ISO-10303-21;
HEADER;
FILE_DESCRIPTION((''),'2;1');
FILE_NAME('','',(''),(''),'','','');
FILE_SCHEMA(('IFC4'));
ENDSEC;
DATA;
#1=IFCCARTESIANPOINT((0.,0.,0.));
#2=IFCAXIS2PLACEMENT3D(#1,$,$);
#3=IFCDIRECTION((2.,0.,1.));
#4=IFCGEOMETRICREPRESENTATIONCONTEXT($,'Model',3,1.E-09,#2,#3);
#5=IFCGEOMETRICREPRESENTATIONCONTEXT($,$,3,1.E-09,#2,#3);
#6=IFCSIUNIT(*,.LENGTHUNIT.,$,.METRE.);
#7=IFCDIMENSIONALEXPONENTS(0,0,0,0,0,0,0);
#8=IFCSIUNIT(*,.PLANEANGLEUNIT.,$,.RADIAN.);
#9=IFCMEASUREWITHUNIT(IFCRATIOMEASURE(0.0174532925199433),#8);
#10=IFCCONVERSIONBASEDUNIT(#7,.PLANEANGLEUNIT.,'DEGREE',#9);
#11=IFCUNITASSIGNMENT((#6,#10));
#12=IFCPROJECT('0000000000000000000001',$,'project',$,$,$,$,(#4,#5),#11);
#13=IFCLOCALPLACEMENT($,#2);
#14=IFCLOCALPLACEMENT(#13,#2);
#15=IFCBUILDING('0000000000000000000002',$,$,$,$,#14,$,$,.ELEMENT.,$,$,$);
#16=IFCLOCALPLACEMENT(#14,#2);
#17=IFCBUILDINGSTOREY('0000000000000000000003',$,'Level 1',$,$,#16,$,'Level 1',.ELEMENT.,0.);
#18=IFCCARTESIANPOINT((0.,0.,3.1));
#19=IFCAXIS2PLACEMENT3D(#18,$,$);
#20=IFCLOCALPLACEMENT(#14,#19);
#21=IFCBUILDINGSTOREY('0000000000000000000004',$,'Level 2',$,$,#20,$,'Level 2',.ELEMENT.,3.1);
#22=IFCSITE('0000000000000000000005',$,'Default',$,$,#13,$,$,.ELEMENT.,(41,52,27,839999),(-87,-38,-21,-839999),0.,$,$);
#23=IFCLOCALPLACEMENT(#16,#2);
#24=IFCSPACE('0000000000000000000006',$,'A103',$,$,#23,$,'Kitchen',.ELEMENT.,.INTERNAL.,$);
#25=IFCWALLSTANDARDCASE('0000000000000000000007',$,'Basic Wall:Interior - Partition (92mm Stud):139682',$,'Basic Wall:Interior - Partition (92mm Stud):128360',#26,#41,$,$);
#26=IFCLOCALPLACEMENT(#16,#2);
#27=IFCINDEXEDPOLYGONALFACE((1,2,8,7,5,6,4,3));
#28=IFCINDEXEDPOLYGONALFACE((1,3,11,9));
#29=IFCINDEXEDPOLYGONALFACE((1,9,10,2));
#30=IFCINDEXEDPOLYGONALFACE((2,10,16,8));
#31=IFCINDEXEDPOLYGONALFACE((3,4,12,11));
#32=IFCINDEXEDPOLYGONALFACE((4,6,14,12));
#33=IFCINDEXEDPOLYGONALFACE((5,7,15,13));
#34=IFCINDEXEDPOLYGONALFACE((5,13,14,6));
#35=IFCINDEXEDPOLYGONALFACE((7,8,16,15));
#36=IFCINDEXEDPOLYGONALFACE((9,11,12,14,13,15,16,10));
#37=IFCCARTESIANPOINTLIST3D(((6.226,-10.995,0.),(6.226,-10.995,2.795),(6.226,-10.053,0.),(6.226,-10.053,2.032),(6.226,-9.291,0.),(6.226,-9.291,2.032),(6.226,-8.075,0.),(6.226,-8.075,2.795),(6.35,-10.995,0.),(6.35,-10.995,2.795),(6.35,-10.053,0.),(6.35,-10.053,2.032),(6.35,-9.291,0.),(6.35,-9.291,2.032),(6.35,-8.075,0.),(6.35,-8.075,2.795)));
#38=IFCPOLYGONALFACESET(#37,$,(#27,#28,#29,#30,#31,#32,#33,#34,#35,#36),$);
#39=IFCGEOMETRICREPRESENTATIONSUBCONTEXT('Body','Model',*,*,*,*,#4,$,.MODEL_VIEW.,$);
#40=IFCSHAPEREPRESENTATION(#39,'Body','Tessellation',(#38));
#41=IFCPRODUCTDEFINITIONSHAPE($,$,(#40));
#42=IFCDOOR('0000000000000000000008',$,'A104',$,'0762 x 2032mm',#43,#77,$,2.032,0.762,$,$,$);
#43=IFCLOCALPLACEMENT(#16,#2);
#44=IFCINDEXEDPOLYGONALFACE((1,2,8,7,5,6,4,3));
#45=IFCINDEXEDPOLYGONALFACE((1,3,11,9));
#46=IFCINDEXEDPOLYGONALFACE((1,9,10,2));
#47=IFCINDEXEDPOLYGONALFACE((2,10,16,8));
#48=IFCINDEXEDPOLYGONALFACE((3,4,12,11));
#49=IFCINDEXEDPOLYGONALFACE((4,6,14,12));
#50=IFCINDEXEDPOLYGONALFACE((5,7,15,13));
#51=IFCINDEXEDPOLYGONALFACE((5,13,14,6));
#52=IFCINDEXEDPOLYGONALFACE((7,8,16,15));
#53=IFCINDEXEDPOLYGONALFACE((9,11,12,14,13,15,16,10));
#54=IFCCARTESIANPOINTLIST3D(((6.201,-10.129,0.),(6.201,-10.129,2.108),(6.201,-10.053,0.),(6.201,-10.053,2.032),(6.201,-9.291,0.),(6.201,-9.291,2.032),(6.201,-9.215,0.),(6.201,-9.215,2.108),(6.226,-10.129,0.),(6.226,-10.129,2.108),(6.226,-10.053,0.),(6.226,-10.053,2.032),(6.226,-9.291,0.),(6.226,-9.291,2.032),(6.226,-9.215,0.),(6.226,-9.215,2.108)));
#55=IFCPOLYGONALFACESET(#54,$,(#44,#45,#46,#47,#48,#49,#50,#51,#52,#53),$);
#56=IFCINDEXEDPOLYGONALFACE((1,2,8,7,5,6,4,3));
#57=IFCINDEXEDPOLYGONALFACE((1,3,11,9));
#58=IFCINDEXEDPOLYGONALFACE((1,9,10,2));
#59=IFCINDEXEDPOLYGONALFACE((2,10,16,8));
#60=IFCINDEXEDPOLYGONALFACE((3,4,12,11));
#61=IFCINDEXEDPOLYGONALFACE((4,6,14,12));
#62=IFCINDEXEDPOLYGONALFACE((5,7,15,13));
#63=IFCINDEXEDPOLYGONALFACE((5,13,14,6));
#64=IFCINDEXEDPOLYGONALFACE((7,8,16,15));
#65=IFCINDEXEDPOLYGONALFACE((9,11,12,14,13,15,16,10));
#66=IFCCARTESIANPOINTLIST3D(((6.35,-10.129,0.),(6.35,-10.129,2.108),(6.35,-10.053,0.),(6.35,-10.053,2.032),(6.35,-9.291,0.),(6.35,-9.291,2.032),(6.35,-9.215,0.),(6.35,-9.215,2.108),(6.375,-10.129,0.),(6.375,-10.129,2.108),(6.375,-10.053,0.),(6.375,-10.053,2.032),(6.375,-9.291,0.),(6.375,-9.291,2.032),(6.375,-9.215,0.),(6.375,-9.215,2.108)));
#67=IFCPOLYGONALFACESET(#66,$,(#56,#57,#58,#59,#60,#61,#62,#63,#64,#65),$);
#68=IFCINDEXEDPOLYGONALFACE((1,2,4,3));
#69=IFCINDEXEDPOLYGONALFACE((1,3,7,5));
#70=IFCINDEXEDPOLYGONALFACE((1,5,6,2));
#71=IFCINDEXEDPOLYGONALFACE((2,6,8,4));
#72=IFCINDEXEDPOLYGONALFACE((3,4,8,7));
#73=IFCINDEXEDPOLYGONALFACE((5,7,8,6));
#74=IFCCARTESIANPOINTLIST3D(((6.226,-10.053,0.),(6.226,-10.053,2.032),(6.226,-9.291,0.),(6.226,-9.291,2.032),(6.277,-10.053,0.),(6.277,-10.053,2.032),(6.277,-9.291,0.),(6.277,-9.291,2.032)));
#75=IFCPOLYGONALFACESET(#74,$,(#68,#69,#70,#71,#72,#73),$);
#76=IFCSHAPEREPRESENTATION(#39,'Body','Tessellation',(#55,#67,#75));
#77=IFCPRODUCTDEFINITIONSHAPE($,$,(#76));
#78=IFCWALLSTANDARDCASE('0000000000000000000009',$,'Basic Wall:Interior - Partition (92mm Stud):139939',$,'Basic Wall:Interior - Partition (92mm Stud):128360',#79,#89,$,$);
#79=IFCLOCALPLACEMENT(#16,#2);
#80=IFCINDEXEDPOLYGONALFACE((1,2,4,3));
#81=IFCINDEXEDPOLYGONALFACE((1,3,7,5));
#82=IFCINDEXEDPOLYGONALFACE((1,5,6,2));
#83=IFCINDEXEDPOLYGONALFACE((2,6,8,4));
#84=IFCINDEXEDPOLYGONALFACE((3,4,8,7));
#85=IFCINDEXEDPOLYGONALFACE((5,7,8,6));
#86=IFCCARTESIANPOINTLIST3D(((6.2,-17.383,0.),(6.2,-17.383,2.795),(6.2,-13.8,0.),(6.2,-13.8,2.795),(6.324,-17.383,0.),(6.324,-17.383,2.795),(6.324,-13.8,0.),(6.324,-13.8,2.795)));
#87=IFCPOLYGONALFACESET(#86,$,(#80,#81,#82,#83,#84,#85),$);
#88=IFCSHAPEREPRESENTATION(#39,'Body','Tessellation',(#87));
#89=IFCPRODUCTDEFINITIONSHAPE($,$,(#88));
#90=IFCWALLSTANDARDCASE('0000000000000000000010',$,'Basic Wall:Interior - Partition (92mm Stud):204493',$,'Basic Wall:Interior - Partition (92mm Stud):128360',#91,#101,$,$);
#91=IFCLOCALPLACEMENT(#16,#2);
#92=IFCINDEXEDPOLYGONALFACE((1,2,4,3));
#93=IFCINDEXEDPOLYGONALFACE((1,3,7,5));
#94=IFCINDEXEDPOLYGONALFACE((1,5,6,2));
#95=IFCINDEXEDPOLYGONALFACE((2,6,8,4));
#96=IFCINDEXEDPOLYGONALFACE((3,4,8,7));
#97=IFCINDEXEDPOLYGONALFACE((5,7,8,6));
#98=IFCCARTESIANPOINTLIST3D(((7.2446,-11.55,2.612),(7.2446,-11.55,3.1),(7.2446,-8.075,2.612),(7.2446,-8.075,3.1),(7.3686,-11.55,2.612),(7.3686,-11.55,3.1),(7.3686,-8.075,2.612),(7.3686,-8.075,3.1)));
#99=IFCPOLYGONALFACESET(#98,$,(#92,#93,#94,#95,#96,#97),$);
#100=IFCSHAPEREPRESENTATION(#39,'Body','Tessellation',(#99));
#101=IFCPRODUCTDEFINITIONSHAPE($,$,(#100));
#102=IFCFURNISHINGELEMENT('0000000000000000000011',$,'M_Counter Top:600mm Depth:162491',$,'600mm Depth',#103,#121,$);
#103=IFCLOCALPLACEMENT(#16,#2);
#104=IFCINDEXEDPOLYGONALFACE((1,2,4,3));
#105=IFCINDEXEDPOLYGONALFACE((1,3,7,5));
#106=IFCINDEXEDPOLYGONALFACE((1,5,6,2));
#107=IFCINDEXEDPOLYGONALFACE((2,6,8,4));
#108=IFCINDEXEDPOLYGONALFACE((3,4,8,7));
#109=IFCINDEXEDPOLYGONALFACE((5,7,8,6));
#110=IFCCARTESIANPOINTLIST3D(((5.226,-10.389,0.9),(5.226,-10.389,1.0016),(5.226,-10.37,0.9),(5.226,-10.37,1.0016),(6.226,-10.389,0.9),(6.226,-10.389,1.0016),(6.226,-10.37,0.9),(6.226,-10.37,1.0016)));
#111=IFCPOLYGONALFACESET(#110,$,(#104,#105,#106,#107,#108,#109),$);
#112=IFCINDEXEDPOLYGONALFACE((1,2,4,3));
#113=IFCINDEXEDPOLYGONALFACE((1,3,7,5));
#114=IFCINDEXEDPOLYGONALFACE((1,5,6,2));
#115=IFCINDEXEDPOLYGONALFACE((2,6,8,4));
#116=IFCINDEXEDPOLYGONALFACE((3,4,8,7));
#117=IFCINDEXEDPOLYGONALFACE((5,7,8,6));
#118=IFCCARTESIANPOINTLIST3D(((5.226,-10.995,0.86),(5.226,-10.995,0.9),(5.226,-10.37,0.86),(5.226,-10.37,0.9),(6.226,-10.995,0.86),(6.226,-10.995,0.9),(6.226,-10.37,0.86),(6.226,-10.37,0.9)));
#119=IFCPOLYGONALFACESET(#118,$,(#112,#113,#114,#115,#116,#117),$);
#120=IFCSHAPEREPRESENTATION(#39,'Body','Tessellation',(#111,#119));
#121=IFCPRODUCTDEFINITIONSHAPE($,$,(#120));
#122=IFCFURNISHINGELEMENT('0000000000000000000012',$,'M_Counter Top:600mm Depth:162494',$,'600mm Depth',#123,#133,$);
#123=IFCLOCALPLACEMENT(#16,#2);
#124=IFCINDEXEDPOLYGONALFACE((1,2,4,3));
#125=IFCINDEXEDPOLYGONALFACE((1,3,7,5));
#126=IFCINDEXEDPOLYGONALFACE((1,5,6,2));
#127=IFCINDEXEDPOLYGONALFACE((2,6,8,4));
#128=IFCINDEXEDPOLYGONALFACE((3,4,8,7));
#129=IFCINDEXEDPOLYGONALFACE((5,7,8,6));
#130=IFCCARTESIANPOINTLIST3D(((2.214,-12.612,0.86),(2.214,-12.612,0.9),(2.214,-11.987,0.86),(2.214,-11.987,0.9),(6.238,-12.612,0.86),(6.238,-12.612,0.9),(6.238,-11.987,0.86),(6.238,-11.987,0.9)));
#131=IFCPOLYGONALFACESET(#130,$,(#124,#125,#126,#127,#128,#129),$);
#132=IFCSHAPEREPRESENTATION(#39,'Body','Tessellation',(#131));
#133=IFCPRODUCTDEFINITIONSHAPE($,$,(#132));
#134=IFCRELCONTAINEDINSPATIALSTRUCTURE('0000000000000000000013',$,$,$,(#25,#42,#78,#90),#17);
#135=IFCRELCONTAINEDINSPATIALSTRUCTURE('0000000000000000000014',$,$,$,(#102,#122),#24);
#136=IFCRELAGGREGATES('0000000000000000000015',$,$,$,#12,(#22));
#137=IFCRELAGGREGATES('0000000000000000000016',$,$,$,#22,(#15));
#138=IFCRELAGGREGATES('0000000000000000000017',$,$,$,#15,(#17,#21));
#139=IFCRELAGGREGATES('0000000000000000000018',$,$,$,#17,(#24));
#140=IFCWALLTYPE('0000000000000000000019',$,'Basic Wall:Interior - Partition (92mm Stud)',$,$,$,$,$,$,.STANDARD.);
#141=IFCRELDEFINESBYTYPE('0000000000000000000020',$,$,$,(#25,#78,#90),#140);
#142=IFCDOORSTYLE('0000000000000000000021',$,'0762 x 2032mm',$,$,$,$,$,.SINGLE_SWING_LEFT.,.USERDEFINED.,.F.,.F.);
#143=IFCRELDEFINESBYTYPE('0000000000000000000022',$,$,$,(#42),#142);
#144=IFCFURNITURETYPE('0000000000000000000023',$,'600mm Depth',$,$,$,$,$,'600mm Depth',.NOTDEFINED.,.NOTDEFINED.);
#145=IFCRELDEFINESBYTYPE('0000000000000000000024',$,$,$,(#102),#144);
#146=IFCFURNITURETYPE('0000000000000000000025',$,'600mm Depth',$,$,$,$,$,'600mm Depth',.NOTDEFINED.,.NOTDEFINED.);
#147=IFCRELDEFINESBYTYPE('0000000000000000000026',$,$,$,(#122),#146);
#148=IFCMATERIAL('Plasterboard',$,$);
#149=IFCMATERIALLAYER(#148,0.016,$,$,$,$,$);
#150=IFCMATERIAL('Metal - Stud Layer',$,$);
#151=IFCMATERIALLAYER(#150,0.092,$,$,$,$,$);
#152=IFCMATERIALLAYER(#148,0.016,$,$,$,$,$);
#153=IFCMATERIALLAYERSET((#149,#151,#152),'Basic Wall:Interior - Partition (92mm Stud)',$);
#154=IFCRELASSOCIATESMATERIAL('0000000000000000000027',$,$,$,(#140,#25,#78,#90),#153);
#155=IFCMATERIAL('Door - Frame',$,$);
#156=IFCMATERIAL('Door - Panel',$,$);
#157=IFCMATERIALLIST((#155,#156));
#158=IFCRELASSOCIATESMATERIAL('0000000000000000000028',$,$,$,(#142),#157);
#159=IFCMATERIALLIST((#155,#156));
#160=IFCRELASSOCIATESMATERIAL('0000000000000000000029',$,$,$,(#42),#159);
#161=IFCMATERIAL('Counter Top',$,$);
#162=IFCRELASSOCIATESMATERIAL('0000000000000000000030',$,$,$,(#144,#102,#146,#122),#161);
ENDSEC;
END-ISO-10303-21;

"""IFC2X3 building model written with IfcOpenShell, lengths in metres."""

from ifc_helpers import new_model, entity, si_unit, converted_unit, direction, frame, frame_2d, origin, place, context, subcontext, project, spatial, polyline, rectangle, outline, extrude, source, transform, mapped, material, material_list, layer, layer_set, layer_usage, type_object, type_shapes, element, fill, save


model = new_model("IFC2X3")

# Units and contexts
model_context = context("Model", 3, precision=1e-09, world=origin(), true_north=direction((2.0, 0.0, 1.0)))
context_of_model = context(None, 3, precision=1e-09, world=origin(), true_north=direction((2.0, 0.0, 1.0)))
body_context = subcontext(model_context, "Body", "Model", "MODEL_VIEW")
ifc_project = project(units=[si_unit("LENGTHUNIT", "METRE"), converted_unit("PLANEANGLEUNIT", "DEGREE", entity("IfcRatioMeasure", 0.0174532925199433), si_unit("PLANEANGLEUNIT", "RADIAN"), dimensions=[0, 0, 0, 0, 0, 0, 0])], contexts=[model_context, context_of_model])

# Site, building, storey
site_placement = place(None, origin())
site = spatial("IfcSite", under=ifc_project, at=site_placement, Name="Default", CompositionType="ELEMENT", RefLatitude=(41, 52, 27, 839999), RefLongitude=(-87, -38, -21, -839999), RefElevation=0.0)
building_placement = place(site_placement, origin())
building = spatial("IfcBuilding", under=site, at=building_placement, CompositionType="ELEMENT")
storey_1_placement = place(building_placement, origin())
storey_1 = spatial("IfcBuildingStorey", under=building, at=storey_1_placement, Name="Level 1", LongName="Level 1", CompositionType="ELEMENT", Elevation=0.0)

# Shared definitions
ifc_material_1 = material(Name="Metal - Stud Layer")
ifc_material_2 = material(Name="Plasterboard")
ifc_material_3 = material(Name="Door - Frame")
ifc_material_4 = material(Name="Door - Panel")

# Wall, opening, door
ifc_layer_1 = layer(ifc_material_2, 0.016)
ifc_layer_2 = layer(ifc_material_1, 0.092)
ifc_layer_3 = layer(ifc_material_2, 0.016)
ifc_layer_set_1 = layer_set([ifc_layer_1, ifc_layer_2, ifc_layer_3], Name="Basic Wall:Interior - Partition (92mm Stud)")
ifc_layer_usage_1 = layer_usage(ifc_layer_set_1, "AXIS2", "NEGATIVE", 0.062)
wall_type_1 = type_object("IfcWallType", Name="Basic Wall:Interior - Partition (92mm Stud)", PredefinedType="STANDARD", material=ifc_layer_set_1)
wall_1_placement = place(storey_1_placement, frame((6.288, -10.995, 0.0), z_axis=(0.0, 0.0, 1.0), x_axis=(0.0, 1.0, 0.0)))
wall_1 = element("IfcWallStandardCase", 1, at=wall_1_placement, inside=storey_1, type_object=wall_type_1, material=ifc_layer_usage_1, Name="Basic Wall:Interior - Partition (92mm Stud):139682", ObjectType="Basic Wall:Interior - Partition (92mm Stud):128360", context=body_context, shape_type="SweptSolid", body=[
    extrude(rectangle(XDim=2.92, YDim=0.124, at=frame_2d((1.46, 0.0), x_axis=(-1.0, 0.0))), origin(), (0.0, 0.0, 1.0), 2.795),
])
opening_1_placement = place(wall_1_placement, frame((0.942, -0.062, 0.0)))
opening_1 = element("IfcOpeningElement", 2, at=opening_1_placement, cuts=wall_1, ObjectType="Opening", context=body_context, shape_type="SweptSolid", body=[
    extrude(rectangle(XDim=0.762, YDim=2.032, at=frame_2d((1.016, 0.381), x_axis=(0.0, -1.0))), frame((0.0, 0.0, 0.0), z_axis=(0.0, 1.0, 0.0), x_axis=(0.0, 0.0, 1.0)), (0.0, 0.0, 1.0), 0.124),
])
ifc_material_list_1 = material_list([ifc_material_3, ifc_material_4])
ifc_material_list_2 = material_list([ifc_material_3, ifc_material_4])
door_style_1 = type_object("IfcDoorStyle", Name="0762 x 2032mm", ConstructionType="USERDEFINED", OperationType="SINGLE_SWING_LEFT", ParameterTakesPrecedence=False, Sizeable=False, material=ifc_material_list_2)
shared_shape_1 = source(origin(), body_context, "Body", "SweptSolid", [
    extrude(outline(polyline([(-0.457, -1.073), (0.457, -1.073), (0.457, 1.035), (0.381, 1.035), (0.381, -0.997), (-0.381, -0.997), (-0.381, 1.035), (-0.457, 1.035), (-0.457, -1.073)])), frame((0.381, 0.149, 1.035), z_axis=(0.0, -1.0, 0.0), x_axis=(-1.0, 0.0, 0.0)), (0.0, 0.0, 1.0), 0.025),
    extrude(outline(polyline([(-1.073, -0.457), (1.035, -0.457), (1.035, -0.381), (-0.997, -0.381), (-0.997, 0.381), (1.035, 0.381), (1.035, 0.457), (-1.073, 0.457), (-1.073, -0.457)])), frame((0.381, 0.0, 1.035), z_axis=(0.0, -1.0, 0.0), x_axis=(0.0, 0.0, -1.0)), (0.0, 0.0, 1.0), 0.025),
    extrude(rectangle(XDim=0.762, YDim=0.051, at=frame_2d((0.0, 0.0), x_axis=(1.0, 0.0))), frame((0.381, 0.0985, 0.0)), (0.0, 0.0, 1.0), 2.032),
])
type_shapes(door_style_1, [shared_shape_1])
door_1_placement = place(opening_1_placement, origin())
door_1 = element("IfcDoor", 3, at=door_1_placement, inside=storey_1, type_object=door_style_1, material=ifc_material_list_1, Name="A104", ObjectType="0762 x 2032mm", OverallHeight=2.032, OverallWidth=0.762, context=body_context, shape_type="MappedRepresentation", body=[
    mapped(shared_shape_1, transform((0.0, 0.0, 0.0), scale=1.0)),
])
fill(opening_1, door_1)

# Wall
ifc_layer_usage_2 = layer_usage(ifc_layer_set_1, "AXIS2", "NEGATIVE", 0.062)
wall_2_placement = place(storey_1_placement, frame((6.262, -13.8, 0.0), z_axis=(0.0, 0.0, 1.0), x_axis=(0.0, -1.0, 0.0)))
element("IfcWallStandardCase", 4, at=wall_2_placement, inside=storey_1, type_object=wall_type_1, material=ifc_layer_usage_2, Name="Basic Wall:Interior - Partition (92mm Stud):139939", ObjectType="Basic Wall:Interior - Partition (92mm Stud):128360", context=body_context, shape_type="SweptSolid", body=[
    extrude(rectangle(XDim=3.583, YDim=0.124, at=frame_2d((1.7915, 0.0), x_axis=(-1.0, 0.0))), origin(), (0.0, 0.0, 1.0), 2.795),
])

# Shared definitions
storey_2_placement = place(building_placement, frame((0.0, 0.0, 3.1)))
storey_2 = spatial("IfcBuildingStorey", under=building, at=storey_2_placement, Name="Level 2", LongName="Level 2", CompositionType="ELEMENT", Elevation=3.1)

# Wall
ifc_layer_usage_3 = layer_usage(ifc_layer_set_1, "AXIS2", "NEGATIVE", 0.062)
wall_3_placement = place(storey_1_placement, frame((7.3066, -11.55, 2.612), z_axis=(0.0, 0.0, 1.0), x_axis=(0.0, 1.0, 0.0)))
element("IfcWallStandardCase", 5, at=wall_3_placement, inside=storey_1, type_object=wall_type_1, material=ifc_layer_usage_3, Name="Basic Wall:Interior - Partition (92mm Stud):204493", ObjectType="Basic Wall:Interior - Partition (92mm Stud):128360", context=body_context, shape_type="SweptSolid", body=[
    extrude(rectangle(XDim=3.475, YDim=0.124, at=frame_2d((1.7375, 0.0), x_axis=(-1.0, 0.0))), origin(), (0.0, 0.0, 1.0), 0.488),
])

# Shared definitions
space_1_placement = place(storey_1_placement, origin())
space_1 = spatial("IfcSpace", under=storey_1, at=space_1_placement, Name="A103", LongName="Kitchen", CompositionType="ELEMENT", InteriorOrExteriorSpace="INTERNAL")

# Furnishing elements
ifc_material_5 = material(Name="Counter Top")
furniture_type_1 = type_object("IfcFurnitureType", Name="600mm Depth", ElementType="600mm Depth", AssemblyPlace="NOTDEFINED", material=ifc_material_5)
shared_shape_2 = source(origin(), body_context, "Body", "SweptSolid", [
    extrude(rectangle(XDim=0.0191, YDim=1.0, at=frame_2d((0.0, 0.0), x_axis=(1.0, 0.0))), frame((-0.7005, -0.0095, 0.9), z_axis=(0.0, 0.0, 1.0), x_axis=(0.0, -1.0, 0.0)), (0.0, 0.0, 1.0), 0.1016),
    extrude(rectangle(XDim=1.0, YDim=0.625, at=frame_2d((0.0, 0.0), x_axis=(1.0, 0.0))), frame((-0.7005, -0.3125, 0.86), z_axis=(0.0, 0.0, 1.0), x_axis=(-1.0, 0.0, 0.0)), (0.0, 0.0, 1.0), 0.04),
])
type_shapes(furniture_type_1, [shared_shape_2])
furnishing_1_placement = place(space_1_placement, frame((6.4265, -10.37, 0.0)))
element("IfcFurnishingElement", 6, at=furnishing_1_placement, inside=space_1, type_object=furniture_type_1, material=ifc_material_5, Name="M_Counter Top:600mm Depth:162491", ObjectType="600mm Depth", context=body_context, shape_type="MappedRepresentation", body=[
    mapped(shared_shape_2, transform((0.0, 0.0, 0.0), scale=1.0)),
])
furniture_type_2 = type_object("IfcFurnitureType", Name="600mm Depth", ElementType="600mm Depth", AssemblyPlace="NOTDEFINED", material=ifc_material_5)
shared_shape_3 = source(origin(), body_context, "Body", "SweptSolid", [
    extrude(rectangle(XDim=4.024, YDim=0.625, at=frame_2d((0.0, 0.0), x_axis=(1.0, 0.0))), frame((0.8115, -0.3125, 0.86), z_axis=(0.0, 0.0, 1.0), x_axis=(-1.0, 0.0, 0.0)), (0.0, 0.0, 1.0), 0.04),
])
type_shapes(furniture_type_2, [shared_shape_3])
furnishing_2_placement = place(space_1_placement, frame((5.0375, -12.612, 0.0), z_axis=(0.0, 0.0, 1.0), x_axis=(-1.0, 0.0, 0.0)))
element("IfcFurnishingElement", 7, at=furnishing_2_placement, inside=space_1, type_object=furniture_type_2, material=ifc_material_5, Name="M_Counter Top:600mm Depth:162494", ObjectType="600mm Depth", context=body_context, shape_type="MappedRepresentation", body=[
    mapped(shared_shape_3, transform((0.0, 0.0, 0.0), scale=1.0)),
])

save(model, "model.ifc")
